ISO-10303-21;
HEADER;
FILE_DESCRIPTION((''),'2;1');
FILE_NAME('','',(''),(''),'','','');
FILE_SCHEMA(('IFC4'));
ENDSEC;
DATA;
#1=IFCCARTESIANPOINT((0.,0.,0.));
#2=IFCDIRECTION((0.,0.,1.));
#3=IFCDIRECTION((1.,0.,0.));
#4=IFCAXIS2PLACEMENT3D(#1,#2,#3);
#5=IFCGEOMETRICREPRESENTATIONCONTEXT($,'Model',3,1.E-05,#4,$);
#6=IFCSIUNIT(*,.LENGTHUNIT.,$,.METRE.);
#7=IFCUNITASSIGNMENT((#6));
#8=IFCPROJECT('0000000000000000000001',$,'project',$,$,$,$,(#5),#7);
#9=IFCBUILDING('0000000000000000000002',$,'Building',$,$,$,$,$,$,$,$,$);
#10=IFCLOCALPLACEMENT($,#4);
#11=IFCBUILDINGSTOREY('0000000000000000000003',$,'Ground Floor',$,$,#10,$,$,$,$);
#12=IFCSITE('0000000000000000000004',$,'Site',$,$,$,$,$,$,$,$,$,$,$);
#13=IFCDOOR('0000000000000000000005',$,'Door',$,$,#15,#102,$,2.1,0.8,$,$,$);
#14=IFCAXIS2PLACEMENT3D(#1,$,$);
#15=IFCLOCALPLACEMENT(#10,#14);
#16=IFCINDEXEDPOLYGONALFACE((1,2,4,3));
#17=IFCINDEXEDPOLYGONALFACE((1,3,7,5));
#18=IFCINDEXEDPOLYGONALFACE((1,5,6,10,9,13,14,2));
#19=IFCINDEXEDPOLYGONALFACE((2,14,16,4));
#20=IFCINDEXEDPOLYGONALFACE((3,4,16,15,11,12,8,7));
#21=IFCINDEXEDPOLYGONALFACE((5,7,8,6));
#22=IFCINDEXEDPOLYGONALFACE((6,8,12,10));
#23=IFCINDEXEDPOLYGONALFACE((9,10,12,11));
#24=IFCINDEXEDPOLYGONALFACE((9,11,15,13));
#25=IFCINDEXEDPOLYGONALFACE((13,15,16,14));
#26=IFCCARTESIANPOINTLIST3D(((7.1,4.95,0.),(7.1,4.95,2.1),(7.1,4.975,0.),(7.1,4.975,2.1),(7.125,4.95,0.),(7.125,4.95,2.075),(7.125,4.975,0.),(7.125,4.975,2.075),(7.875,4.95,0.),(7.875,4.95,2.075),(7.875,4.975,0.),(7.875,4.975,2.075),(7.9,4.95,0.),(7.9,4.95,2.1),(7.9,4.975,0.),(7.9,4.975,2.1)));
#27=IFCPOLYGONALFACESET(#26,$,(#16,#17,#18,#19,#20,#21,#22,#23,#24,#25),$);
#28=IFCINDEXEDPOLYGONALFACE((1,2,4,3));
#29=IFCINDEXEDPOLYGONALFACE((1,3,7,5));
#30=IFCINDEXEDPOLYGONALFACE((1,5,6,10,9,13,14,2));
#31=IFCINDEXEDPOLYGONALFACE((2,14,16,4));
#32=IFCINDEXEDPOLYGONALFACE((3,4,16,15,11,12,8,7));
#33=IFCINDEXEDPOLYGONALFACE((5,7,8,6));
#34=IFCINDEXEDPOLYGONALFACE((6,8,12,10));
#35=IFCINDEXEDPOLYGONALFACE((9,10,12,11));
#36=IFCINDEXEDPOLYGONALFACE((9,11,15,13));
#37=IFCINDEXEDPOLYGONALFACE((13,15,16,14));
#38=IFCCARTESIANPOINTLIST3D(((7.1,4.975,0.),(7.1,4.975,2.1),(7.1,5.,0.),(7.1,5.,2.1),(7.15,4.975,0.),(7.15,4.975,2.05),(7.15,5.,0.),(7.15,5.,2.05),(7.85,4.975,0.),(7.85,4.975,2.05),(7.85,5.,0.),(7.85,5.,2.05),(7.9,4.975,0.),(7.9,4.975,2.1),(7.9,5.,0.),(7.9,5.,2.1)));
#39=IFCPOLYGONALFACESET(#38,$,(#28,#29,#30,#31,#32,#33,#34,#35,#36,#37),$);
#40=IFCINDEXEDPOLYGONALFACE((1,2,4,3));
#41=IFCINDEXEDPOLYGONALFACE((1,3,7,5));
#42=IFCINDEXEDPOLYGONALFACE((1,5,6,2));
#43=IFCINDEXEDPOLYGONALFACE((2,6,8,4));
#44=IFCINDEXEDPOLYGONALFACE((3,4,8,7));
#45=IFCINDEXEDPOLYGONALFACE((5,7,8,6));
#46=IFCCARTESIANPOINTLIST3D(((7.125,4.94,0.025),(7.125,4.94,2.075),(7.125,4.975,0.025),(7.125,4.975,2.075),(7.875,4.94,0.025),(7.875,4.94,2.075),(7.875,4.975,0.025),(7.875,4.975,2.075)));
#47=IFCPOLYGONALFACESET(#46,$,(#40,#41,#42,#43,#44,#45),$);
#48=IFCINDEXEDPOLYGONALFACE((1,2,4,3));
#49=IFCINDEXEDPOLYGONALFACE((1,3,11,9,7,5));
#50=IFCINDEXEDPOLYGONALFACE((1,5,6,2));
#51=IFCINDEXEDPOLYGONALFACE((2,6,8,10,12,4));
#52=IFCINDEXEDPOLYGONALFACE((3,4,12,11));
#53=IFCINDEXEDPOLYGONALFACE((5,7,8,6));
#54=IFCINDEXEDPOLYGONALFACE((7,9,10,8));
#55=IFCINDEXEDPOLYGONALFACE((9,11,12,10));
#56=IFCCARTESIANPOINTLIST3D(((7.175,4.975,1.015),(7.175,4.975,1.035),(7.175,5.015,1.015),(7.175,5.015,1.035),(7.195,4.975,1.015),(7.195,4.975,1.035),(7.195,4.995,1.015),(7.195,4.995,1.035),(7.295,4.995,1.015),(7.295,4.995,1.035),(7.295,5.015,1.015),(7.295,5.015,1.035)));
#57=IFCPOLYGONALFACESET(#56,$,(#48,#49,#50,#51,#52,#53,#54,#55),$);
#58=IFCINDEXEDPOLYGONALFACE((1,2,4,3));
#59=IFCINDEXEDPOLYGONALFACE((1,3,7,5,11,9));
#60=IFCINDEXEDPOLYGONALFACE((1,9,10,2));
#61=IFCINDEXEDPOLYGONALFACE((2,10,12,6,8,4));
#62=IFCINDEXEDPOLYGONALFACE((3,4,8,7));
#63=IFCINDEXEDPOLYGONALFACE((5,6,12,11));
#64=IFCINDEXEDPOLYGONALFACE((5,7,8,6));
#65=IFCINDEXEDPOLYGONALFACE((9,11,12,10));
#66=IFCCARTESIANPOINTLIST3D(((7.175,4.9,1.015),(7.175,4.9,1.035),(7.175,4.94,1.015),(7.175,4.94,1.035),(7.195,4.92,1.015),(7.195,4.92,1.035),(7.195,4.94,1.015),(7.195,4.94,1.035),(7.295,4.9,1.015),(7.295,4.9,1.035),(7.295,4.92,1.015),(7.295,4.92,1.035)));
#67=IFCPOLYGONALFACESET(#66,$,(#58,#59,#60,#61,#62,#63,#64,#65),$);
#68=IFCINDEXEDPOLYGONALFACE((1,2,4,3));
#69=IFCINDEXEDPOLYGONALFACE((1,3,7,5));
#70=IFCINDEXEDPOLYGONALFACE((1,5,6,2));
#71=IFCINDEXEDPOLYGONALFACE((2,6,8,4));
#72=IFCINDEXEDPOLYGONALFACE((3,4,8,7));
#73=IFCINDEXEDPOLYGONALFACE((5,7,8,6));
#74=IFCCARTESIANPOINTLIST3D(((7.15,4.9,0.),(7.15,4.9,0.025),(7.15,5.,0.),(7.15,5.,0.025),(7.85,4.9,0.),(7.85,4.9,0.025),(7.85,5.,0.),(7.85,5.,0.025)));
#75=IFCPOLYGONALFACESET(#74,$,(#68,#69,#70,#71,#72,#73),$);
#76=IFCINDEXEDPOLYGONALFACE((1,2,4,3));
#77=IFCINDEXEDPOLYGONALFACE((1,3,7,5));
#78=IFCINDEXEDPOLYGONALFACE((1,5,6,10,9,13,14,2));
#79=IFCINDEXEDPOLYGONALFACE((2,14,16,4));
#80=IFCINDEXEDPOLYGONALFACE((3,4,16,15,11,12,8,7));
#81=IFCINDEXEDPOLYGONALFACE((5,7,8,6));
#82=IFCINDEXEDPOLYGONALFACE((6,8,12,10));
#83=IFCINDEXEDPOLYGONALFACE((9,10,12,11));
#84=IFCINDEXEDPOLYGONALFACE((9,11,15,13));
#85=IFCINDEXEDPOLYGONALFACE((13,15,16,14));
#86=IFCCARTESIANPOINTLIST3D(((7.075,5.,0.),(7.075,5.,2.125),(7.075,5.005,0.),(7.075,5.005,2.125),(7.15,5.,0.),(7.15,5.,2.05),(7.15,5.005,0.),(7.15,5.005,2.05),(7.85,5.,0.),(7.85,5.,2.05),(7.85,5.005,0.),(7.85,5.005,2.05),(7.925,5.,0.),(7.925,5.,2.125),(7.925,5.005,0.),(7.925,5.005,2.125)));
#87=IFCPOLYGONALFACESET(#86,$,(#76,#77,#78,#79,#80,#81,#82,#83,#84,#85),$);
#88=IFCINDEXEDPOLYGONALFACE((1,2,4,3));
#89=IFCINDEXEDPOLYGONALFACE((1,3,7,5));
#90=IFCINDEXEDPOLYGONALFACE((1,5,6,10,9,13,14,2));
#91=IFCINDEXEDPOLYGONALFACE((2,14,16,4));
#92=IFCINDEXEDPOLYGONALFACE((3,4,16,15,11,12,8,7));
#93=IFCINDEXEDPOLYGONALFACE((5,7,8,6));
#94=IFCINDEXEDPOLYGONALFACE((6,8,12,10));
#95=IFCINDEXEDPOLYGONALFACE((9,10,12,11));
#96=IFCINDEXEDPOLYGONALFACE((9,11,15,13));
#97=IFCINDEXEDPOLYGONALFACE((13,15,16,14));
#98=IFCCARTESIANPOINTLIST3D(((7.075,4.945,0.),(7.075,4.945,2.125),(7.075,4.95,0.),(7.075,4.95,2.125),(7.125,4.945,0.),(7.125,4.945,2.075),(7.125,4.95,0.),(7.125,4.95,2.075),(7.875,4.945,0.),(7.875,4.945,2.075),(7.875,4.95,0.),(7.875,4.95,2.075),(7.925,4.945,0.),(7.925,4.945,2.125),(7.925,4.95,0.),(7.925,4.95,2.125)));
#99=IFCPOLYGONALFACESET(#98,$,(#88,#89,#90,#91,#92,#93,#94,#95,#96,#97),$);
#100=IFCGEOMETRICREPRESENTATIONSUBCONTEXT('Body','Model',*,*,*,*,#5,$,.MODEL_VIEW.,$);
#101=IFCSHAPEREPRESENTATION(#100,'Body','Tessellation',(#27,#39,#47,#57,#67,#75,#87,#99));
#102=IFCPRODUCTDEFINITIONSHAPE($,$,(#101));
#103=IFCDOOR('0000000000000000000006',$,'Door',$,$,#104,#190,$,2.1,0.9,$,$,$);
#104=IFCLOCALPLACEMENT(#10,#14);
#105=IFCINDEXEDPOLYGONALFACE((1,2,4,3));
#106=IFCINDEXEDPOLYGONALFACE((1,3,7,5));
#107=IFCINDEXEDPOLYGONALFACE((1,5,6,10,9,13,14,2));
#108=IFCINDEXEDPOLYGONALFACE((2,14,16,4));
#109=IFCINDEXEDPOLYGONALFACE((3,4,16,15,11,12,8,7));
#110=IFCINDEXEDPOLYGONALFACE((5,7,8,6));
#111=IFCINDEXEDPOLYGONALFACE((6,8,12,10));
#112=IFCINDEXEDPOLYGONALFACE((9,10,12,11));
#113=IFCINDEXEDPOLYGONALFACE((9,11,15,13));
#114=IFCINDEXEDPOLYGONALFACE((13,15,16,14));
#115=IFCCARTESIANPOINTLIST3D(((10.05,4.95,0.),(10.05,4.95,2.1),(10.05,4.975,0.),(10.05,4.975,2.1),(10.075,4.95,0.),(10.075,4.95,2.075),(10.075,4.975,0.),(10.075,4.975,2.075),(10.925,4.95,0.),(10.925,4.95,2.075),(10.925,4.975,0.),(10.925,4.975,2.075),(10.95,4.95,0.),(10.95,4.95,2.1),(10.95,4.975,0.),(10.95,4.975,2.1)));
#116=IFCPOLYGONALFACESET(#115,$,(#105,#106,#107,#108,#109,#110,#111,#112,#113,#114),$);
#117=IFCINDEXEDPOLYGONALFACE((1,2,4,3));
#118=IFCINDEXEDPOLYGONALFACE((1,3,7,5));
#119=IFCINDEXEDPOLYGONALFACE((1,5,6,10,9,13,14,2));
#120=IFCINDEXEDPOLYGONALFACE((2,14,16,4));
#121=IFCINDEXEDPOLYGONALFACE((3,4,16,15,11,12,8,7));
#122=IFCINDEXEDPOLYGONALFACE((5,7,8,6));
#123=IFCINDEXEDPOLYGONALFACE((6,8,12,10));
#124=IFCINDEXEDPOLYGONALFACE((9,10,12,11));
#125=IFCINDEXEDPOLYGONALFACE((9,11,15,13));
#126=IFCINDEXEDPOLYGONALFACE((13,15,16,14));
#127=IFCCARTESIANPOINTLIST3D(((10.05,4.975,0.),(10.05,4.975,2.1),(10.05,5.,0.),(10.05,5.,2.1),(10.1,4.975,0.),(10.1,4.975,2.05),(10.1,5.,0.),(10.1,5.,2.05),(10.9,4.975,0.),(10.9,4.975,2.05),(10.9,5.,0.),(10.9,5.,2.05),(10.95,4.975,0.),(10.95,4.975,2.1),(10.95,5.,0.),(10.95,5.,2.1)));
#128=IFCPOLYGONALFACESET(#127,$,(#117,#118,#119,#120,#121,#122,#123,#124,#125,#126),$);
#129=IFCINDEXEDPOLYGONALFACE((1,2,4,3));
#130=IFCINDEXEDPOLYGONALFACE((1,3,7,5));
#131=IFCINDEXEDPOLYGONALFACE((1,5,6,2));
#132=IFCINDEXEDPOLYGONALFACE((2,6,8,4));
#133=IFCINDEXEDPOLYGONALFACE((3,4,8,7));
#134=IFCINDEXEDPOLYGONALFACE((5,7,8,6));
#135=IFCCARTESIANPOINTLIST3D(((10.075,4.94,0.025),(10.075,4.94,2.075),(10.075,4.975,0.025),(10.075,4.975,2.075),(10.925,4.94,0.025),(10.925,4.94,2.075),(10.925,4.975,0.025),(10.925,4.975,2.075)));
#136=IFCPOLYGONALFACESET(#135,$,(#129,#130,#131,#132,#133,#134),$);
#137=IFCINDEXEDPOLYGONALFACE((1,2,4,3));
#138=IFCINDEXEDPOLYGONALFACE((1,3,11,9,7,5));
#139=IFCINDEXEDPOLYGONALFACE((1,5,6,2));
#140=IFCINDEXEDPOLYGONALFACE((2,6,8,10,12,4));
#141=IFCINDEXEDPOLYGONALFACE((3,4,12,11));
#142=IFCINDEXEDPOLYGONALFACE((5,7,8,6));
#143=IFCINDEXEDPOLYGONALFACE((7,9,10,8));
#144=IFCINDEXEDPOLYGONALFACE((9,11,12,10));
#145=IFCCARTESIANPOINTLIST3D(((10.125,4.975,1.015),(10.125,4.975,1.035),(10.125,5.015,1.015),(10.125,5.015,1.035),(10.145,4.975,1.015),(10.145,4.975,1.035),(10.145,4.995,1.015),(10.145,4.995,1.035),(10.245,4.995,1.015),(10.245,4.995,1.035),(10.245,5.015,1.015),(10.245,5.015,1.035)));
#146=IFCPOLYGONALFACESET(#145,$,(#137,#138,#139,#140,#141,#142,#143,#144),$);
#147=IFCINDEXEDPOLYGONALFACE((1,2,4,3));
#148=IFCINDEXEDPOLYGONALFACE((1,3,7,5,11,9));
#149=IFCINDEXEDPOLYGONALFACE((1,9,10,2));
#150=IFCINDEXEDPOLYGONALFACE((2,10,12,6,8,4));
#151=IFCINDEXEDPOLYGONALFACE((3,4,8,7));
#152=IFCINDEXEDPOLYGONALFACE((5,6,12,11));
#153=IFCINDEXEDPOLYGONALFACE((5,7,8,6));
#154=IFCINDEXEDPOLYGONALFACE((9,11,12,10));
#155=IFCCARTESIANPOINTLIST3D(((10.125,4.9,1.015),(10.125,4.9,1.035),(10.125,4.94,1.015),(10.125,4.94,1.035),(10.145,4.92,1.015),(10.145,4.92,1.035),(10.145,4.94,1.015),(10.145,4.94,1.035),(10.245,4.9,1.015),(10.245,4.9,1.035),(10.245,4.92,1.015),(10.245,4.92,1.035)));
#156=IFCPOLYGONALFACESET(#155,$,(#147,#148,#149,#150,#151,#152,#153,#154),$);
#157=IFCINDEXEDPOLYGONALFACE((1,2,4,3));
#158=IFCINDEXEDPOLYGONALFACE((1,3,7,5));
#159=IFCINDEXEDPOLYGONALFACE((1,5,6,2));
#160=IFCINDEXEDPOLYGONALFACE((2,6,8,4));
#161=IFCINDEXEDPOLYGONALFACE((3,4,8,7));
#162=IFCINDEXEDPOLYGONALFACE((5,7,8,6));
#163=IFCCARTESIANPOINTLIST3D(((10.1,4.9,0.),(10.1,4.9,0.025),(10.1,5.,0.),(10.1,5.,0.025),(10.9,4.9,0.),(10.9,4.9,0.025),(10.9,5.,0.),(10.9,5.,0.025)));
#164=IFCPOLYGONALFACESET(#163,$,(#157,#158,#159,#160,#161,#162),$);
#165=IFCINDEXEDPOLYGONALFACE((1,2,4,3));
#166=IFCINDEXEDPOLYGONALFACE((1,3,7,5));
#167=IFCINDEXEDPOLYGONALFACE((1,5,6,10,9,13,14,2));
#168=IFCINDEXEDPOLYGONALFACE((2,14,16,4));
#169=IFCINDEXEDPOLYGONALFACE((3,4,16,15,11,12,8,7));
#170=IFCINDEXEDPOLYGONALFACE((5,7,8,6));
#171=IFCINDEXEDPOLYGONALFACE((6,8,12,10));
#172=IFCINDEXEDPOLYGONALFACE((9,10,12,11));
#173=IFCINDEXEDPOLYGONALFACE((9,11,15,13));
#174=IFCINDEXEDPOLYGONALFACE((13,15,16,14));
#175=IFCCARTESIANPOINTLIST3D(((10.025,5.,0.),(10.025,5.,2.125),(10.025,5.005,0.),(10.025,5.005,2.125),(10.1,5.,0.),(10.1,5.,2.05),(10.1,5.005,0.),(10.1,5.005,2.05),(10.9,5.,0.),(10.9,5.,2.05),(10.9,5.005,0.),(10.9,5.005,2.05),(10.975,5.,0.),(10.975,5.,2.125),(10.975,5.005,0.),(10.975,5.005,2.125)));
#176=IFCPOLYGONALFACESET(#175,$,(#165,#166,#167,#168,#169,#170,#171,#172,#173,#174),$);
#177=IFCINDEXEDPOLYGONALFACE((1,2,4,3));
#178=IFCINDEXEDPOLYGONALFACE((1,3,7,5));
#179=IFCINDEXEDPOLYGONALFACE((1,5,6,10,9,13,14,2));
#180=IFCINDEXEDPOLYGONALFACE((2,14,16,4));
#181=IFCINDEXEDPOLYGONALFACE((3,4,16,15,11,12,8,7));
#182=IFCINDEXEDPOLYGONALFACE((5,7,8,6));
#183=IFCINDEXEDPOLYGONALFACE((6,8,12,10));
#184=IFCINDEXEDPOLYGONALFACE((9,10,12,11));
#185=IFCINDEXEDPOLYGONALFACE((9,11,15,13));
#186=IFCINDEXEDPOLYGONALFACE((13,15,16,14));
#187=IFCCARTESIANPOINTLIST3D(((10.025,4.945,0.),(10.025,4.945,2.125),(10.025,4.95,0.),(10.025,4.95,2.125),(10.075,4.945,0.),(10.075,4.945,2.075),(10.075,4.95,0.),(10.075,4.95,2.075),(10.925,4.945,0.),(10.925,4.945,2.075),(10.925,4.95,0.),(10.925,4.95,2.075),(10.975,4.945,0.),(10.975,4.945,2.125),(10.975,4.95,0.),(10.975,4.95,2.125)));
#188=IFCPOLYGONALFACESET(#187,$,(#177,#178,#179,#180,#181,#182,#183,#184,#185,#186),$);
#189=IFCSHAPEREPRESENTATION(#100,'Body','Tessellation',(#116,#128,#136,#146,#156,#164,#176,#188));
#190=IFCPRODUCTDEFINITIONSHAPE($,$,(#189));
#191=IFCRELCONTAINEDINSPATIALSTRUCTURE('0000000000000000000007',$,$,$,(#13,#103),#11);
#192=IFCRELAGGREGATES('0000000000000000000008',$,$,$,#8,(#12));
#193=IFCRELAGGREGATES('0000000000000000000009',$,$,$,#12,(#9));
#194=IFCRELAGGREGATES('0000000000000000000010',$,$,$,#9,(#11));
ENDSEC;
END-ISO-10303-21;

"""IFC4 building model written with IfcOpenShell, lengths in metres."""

from ifc_helpers import new_model, si_unit, frame, origin_with_axes, place, context, subcontext, project, spatial, line, indexed_curve, outline, extrude, element, save


model = new_model("IFC4")

# Units and contexts
model_context = context("Model", 3, precision=1e-05, world=origin_with_axes())
body_context = subcontext(model_context, "Body", "Model", "MODEL_VIEW")
ifc_project = project(units=[si_unit("LENGTHUNIT", "METRE")], contexts=[model_context])

# Site, building, storey
site = spatial("IfcSite", under=ifc_project, Name="Site")
building = spatial("IfcBuilding", under=site, Name="Building")
storey_placement = place(None, origin_with_axes())
storey = spatial("IfcBuildingStorey", under=building, at=storey_placement, Name="Ground Floor")

# Doors
door_1_placement = place(storey_placement, frame((7.9, 5.0, 0.0), z_axis=(0.0, 0.0, 1.0), x_axis=(-1.0, 0.0, 0.0)))
element("IfcDoor", 1, at=door_1_placement, inside=storey, Name="Door", OverallHeight=2.1, OverallWidth=0.8, context=body_context, shape_type="SweptSolid", body=[
    extrude(outline(indexed_curve([(0.0, 0.0), (0.0, 2.1), (0.8, 2.1), (0.8, 0.0), (0.775, 0.0), (0.775, 2.075), (0.025, 2.075), (0.025, 0.0)], segments=[line(1, 2, 3, 4, 5, 6, 7, 8, 1)])), frame((0.0, 0.025, 0.0), z_axis=(0.0, -1.0, 0.0), x_axis=(1.0, 0.0, 0.0)), (0.0, 0.0, -1.0), 0.025),
    extrude(outline(indexed_curve([(0.0, 0.0), (0.0, 2.1), (0.8, 2.1), (0.8, 0.0), (0.75, 0.0), (0.75, 2.05), (0.05, 2.05), (0.05, 0.0)], segments=[line(1, 2, 3, 4, 5, 6, 7, 8, 1)])), frame((0.0, 0.0, 0.0), z_axis=(0.0, -1.0, 0.0), x_axis=(1.0, 0.0, 0.0)), (0.0, 0.0, -1.0), 0.025),
    extrude(outline(indexed_curve([(0.0, 0.0), (0.75, 0.0), (0.75, 0.035), (0.0, 0.035)], segments=[line(1, 2, 3, 4, 1)])), frame((0.025, 0.025, 0.025), z_axis=(0.0, 0.0, 1.0), x_axis=(1.0, 0.0, 0.0)), (0.0, 0.0, 1.0), 2.05),
    extrude(outline(indexed_curve([(0.0, 0.0), (0.0, -0.04), (-0.12, -0.04), (-0.12, -0.02), (-0.02, -0.02), (-0.02, 0.0)], segments=[line(1, 2, 3, 4, 5, 6, 1)])), frame((0.725, 0.025, 1.015), z_axis=(0.0, 0.0, 1.0), x_axis=(1.0, 0.0, 0.0)), (0.0, 0.0, 1.0), 0.02),
    extrude(outline(indexed_curve([(0.0, 0.0), (0.0, 0.04), (-0.12, 0.04), (-0.12, 0.02), (-0.02, 0.02), (-0.02, 0.0)], segments=[line(1, 2, 3, 4, 5, 6, 1)])), frame((0.725, 0.06, 1.015), z_axis=(0.0, 0.0, 1.0), x_axis=(1.0, 0.0, 0.0)), (0.0, 0.0, 1.0), 0.02),
    extrude(outline(indexed_curve([(0.0, 0.0), (0.7, 0.0), (0.7, 0.1), (0.0, 0.1)], segments=[line(1, 2, 3, 4, 1)])), frame((0.05, 0.0, 0.0), z_axis=(0.0, 0.0, 1.0), x_axis=(1.0, 0.0, 0.0)), (0.0, 0.0, 1.0), 0.025),
    extrude(outline(indexed_curve([(0.0, 0.0), (0.0, 2.125), (0.85, 2.125), (0.85, 0.0), (0.775, 0.0), (0.775, 2.05), (0.075, 2.05), (0.075, 0.0)], segments=[line(1, 2, 3, 4, 5, 6, 7, 8, 1)])), frame((-0.025, -0.005, 0.0), z_axis=(0.0, -1.0, 0.0), x_axis=(1.0, 0.0, 0.0)), (0.0, 0.0, -1.0), 0.005),
    extrude(outline(indexed_curve([(0.0, 0.0), (0.0, 2.125), (0.85, 2.125), (0.85, 0.0), (0.8, 0.0), (0.8, 2.075), (0.05, 2.075), (0.05, 0.0)], segments=[line(1, 2, 3, 4, 5, 6, 7, 8, 1)])), frame((-0.025, 0.05, 0.0), z_axis=(0.0, -1.0, 0.0), x_axis=(1.0, 0.0, 0.0)), (0.0, 0.0, -1.0), 0.005),
])
door_2_placement = place(storey_placement, frame((10.95, 5.0, 0.0), z_axis=(0.0, 0.0, 1.0), x_axis=(-1.0, 0.0, 0.0)))
element("IfcDoor", 2, at=door_2_placement, inside=storey, Name="Door", OverallHeight=2.1, OverallWidth=0.9, context=body_context, shape_type="SweptSolid", body=[
    extrude(outline(indexed_curve([(0.0, 0.0), (0.0, 2.1), (0.9, 2.1), (0.9, 0.0), (0.875, 0.0), (0.875, 2.075), (0.025, 2.075), (0.025, 0.0)], segments=[line(1, 2, 3, 4, 5, 6, 7, 8, 1)])), frame((0.0, 0.025, 0.0), z_axis=(0.0, -1.0, 0.0), x_axis=(1.0, 0.0, 0.0)), (0.0, 0.0, -1.0), 0.025),
    extrude(outline(indexed_curve([(0.0, 0.0), (0.0, 2.1), (0.9, 2.1), (0.9, 0.0), (0.85, 0.0), (0.85, 2.05), (0.05, 2.05), (0.05, 0.0)], segments=[line(1, 2, 3, 4, 5, 6, 7, 8, 1)])), frame((0.0, 0.0, 0.0), z_axis=(0.0, -1.0, 0.0), x_axis=(1.0, 0.0, 0.0)), (0.0, 0.0, -1.0), 0.025),
    extrude(outline(indexed_curve([(0.0, 0.0), (0.85, 0.0), (0.85, 0.035), (0.0, 0.035)], segments=[line(1, 2, 3, 4, 1)])), frame((0.025, 0.025, 0.025), z_axis=(0.0, 0.0, 1.0), x_axis=(1.0, 0.0, 0.0)), (0.0, 0.0, 1.0), 2.05),
    extrude(outline(indexed_curve([(0.0, 0.0), (0.0, -0.04), (-0.12, -0.04), (-0.12, -0.02), (-0.02, -0.02), (-0.02, 0.0)], segments=[line(1, 2, 3, 4, 5, 6, 1)])), frame((0.825, 0.025, 1.015), z_axis=(0.0, 0.0, 1.0), x_axis=(1.0, 0.0, 0.0)), (0.0, 0.0, 1.0), 0.02),
    extrude(outline(indexed_curve([(0.0, 0.0), (0.0, 0.04), (-0.12, 0.04), (-0.12, 0.02), (-0.02, 0.02), (-0.02, 0.0)], segments=[line(1, 2, 3, 4, 5, 6, 1)])), frame((0.825, 0.06, 1.015), z_axis=(0.0, 0.0, 1.0), x_axis=(1.0, 0.0, 0.0)), (0.0, 0.0, 1.0), 0.02),
    extrude(outline(indexed_curve([(0.0, 0.0), (0.8, 0.0), (0.8, 0.1), (0.0, 0.1)], segments=[line(1, 2, 3, 4, 1)])), frame((0.05, 0.0, 0.0), z_axis=(0.0, 0.0, 1.0), x_axis=(1.0, 0.0, 0.0)), (0.0, 0.0, 1.0), 0.025),
    extrude(outline(indexed_curve([(0.0, 0.0), (0.0, 2.125), (0.95, 2.125), (0.95, 0.0), (0.875, 0.0), (0.875, 2.05), (0.075, 2.05), (0.075, 0.0)], segments=[line(1, 2, 3, 4, 5, 6, 7, 8, 1)])), frame((-0.025, -0.005, 0.0), z_axis=(0.0, -1.0, 0.0), x_axis=(1.0, 0.0, 0.0)), (0.0, 0.0, -1.0), 0.005),
    extrude(outline(indexed_curve([(0.0, 0.0), (0.0, 2.125), (0.95, 2.125), (0.95, 0.0), (0.9, 0.0), (0.9, 2.075), (0.05, 2.075), (0.05, 0.0)], segments=[line(1, 2, 3, 4, 5, 6, 7, 8, 1)])), frame((-0.025, 0.05, 0.0), z_axis=(0.0, -1.0, 0.0), x_axis=(1.0, 0.0, 0.0)), (0.0, 0.0, -1.0), 0.005),
])

save(model, "model.ifc")
